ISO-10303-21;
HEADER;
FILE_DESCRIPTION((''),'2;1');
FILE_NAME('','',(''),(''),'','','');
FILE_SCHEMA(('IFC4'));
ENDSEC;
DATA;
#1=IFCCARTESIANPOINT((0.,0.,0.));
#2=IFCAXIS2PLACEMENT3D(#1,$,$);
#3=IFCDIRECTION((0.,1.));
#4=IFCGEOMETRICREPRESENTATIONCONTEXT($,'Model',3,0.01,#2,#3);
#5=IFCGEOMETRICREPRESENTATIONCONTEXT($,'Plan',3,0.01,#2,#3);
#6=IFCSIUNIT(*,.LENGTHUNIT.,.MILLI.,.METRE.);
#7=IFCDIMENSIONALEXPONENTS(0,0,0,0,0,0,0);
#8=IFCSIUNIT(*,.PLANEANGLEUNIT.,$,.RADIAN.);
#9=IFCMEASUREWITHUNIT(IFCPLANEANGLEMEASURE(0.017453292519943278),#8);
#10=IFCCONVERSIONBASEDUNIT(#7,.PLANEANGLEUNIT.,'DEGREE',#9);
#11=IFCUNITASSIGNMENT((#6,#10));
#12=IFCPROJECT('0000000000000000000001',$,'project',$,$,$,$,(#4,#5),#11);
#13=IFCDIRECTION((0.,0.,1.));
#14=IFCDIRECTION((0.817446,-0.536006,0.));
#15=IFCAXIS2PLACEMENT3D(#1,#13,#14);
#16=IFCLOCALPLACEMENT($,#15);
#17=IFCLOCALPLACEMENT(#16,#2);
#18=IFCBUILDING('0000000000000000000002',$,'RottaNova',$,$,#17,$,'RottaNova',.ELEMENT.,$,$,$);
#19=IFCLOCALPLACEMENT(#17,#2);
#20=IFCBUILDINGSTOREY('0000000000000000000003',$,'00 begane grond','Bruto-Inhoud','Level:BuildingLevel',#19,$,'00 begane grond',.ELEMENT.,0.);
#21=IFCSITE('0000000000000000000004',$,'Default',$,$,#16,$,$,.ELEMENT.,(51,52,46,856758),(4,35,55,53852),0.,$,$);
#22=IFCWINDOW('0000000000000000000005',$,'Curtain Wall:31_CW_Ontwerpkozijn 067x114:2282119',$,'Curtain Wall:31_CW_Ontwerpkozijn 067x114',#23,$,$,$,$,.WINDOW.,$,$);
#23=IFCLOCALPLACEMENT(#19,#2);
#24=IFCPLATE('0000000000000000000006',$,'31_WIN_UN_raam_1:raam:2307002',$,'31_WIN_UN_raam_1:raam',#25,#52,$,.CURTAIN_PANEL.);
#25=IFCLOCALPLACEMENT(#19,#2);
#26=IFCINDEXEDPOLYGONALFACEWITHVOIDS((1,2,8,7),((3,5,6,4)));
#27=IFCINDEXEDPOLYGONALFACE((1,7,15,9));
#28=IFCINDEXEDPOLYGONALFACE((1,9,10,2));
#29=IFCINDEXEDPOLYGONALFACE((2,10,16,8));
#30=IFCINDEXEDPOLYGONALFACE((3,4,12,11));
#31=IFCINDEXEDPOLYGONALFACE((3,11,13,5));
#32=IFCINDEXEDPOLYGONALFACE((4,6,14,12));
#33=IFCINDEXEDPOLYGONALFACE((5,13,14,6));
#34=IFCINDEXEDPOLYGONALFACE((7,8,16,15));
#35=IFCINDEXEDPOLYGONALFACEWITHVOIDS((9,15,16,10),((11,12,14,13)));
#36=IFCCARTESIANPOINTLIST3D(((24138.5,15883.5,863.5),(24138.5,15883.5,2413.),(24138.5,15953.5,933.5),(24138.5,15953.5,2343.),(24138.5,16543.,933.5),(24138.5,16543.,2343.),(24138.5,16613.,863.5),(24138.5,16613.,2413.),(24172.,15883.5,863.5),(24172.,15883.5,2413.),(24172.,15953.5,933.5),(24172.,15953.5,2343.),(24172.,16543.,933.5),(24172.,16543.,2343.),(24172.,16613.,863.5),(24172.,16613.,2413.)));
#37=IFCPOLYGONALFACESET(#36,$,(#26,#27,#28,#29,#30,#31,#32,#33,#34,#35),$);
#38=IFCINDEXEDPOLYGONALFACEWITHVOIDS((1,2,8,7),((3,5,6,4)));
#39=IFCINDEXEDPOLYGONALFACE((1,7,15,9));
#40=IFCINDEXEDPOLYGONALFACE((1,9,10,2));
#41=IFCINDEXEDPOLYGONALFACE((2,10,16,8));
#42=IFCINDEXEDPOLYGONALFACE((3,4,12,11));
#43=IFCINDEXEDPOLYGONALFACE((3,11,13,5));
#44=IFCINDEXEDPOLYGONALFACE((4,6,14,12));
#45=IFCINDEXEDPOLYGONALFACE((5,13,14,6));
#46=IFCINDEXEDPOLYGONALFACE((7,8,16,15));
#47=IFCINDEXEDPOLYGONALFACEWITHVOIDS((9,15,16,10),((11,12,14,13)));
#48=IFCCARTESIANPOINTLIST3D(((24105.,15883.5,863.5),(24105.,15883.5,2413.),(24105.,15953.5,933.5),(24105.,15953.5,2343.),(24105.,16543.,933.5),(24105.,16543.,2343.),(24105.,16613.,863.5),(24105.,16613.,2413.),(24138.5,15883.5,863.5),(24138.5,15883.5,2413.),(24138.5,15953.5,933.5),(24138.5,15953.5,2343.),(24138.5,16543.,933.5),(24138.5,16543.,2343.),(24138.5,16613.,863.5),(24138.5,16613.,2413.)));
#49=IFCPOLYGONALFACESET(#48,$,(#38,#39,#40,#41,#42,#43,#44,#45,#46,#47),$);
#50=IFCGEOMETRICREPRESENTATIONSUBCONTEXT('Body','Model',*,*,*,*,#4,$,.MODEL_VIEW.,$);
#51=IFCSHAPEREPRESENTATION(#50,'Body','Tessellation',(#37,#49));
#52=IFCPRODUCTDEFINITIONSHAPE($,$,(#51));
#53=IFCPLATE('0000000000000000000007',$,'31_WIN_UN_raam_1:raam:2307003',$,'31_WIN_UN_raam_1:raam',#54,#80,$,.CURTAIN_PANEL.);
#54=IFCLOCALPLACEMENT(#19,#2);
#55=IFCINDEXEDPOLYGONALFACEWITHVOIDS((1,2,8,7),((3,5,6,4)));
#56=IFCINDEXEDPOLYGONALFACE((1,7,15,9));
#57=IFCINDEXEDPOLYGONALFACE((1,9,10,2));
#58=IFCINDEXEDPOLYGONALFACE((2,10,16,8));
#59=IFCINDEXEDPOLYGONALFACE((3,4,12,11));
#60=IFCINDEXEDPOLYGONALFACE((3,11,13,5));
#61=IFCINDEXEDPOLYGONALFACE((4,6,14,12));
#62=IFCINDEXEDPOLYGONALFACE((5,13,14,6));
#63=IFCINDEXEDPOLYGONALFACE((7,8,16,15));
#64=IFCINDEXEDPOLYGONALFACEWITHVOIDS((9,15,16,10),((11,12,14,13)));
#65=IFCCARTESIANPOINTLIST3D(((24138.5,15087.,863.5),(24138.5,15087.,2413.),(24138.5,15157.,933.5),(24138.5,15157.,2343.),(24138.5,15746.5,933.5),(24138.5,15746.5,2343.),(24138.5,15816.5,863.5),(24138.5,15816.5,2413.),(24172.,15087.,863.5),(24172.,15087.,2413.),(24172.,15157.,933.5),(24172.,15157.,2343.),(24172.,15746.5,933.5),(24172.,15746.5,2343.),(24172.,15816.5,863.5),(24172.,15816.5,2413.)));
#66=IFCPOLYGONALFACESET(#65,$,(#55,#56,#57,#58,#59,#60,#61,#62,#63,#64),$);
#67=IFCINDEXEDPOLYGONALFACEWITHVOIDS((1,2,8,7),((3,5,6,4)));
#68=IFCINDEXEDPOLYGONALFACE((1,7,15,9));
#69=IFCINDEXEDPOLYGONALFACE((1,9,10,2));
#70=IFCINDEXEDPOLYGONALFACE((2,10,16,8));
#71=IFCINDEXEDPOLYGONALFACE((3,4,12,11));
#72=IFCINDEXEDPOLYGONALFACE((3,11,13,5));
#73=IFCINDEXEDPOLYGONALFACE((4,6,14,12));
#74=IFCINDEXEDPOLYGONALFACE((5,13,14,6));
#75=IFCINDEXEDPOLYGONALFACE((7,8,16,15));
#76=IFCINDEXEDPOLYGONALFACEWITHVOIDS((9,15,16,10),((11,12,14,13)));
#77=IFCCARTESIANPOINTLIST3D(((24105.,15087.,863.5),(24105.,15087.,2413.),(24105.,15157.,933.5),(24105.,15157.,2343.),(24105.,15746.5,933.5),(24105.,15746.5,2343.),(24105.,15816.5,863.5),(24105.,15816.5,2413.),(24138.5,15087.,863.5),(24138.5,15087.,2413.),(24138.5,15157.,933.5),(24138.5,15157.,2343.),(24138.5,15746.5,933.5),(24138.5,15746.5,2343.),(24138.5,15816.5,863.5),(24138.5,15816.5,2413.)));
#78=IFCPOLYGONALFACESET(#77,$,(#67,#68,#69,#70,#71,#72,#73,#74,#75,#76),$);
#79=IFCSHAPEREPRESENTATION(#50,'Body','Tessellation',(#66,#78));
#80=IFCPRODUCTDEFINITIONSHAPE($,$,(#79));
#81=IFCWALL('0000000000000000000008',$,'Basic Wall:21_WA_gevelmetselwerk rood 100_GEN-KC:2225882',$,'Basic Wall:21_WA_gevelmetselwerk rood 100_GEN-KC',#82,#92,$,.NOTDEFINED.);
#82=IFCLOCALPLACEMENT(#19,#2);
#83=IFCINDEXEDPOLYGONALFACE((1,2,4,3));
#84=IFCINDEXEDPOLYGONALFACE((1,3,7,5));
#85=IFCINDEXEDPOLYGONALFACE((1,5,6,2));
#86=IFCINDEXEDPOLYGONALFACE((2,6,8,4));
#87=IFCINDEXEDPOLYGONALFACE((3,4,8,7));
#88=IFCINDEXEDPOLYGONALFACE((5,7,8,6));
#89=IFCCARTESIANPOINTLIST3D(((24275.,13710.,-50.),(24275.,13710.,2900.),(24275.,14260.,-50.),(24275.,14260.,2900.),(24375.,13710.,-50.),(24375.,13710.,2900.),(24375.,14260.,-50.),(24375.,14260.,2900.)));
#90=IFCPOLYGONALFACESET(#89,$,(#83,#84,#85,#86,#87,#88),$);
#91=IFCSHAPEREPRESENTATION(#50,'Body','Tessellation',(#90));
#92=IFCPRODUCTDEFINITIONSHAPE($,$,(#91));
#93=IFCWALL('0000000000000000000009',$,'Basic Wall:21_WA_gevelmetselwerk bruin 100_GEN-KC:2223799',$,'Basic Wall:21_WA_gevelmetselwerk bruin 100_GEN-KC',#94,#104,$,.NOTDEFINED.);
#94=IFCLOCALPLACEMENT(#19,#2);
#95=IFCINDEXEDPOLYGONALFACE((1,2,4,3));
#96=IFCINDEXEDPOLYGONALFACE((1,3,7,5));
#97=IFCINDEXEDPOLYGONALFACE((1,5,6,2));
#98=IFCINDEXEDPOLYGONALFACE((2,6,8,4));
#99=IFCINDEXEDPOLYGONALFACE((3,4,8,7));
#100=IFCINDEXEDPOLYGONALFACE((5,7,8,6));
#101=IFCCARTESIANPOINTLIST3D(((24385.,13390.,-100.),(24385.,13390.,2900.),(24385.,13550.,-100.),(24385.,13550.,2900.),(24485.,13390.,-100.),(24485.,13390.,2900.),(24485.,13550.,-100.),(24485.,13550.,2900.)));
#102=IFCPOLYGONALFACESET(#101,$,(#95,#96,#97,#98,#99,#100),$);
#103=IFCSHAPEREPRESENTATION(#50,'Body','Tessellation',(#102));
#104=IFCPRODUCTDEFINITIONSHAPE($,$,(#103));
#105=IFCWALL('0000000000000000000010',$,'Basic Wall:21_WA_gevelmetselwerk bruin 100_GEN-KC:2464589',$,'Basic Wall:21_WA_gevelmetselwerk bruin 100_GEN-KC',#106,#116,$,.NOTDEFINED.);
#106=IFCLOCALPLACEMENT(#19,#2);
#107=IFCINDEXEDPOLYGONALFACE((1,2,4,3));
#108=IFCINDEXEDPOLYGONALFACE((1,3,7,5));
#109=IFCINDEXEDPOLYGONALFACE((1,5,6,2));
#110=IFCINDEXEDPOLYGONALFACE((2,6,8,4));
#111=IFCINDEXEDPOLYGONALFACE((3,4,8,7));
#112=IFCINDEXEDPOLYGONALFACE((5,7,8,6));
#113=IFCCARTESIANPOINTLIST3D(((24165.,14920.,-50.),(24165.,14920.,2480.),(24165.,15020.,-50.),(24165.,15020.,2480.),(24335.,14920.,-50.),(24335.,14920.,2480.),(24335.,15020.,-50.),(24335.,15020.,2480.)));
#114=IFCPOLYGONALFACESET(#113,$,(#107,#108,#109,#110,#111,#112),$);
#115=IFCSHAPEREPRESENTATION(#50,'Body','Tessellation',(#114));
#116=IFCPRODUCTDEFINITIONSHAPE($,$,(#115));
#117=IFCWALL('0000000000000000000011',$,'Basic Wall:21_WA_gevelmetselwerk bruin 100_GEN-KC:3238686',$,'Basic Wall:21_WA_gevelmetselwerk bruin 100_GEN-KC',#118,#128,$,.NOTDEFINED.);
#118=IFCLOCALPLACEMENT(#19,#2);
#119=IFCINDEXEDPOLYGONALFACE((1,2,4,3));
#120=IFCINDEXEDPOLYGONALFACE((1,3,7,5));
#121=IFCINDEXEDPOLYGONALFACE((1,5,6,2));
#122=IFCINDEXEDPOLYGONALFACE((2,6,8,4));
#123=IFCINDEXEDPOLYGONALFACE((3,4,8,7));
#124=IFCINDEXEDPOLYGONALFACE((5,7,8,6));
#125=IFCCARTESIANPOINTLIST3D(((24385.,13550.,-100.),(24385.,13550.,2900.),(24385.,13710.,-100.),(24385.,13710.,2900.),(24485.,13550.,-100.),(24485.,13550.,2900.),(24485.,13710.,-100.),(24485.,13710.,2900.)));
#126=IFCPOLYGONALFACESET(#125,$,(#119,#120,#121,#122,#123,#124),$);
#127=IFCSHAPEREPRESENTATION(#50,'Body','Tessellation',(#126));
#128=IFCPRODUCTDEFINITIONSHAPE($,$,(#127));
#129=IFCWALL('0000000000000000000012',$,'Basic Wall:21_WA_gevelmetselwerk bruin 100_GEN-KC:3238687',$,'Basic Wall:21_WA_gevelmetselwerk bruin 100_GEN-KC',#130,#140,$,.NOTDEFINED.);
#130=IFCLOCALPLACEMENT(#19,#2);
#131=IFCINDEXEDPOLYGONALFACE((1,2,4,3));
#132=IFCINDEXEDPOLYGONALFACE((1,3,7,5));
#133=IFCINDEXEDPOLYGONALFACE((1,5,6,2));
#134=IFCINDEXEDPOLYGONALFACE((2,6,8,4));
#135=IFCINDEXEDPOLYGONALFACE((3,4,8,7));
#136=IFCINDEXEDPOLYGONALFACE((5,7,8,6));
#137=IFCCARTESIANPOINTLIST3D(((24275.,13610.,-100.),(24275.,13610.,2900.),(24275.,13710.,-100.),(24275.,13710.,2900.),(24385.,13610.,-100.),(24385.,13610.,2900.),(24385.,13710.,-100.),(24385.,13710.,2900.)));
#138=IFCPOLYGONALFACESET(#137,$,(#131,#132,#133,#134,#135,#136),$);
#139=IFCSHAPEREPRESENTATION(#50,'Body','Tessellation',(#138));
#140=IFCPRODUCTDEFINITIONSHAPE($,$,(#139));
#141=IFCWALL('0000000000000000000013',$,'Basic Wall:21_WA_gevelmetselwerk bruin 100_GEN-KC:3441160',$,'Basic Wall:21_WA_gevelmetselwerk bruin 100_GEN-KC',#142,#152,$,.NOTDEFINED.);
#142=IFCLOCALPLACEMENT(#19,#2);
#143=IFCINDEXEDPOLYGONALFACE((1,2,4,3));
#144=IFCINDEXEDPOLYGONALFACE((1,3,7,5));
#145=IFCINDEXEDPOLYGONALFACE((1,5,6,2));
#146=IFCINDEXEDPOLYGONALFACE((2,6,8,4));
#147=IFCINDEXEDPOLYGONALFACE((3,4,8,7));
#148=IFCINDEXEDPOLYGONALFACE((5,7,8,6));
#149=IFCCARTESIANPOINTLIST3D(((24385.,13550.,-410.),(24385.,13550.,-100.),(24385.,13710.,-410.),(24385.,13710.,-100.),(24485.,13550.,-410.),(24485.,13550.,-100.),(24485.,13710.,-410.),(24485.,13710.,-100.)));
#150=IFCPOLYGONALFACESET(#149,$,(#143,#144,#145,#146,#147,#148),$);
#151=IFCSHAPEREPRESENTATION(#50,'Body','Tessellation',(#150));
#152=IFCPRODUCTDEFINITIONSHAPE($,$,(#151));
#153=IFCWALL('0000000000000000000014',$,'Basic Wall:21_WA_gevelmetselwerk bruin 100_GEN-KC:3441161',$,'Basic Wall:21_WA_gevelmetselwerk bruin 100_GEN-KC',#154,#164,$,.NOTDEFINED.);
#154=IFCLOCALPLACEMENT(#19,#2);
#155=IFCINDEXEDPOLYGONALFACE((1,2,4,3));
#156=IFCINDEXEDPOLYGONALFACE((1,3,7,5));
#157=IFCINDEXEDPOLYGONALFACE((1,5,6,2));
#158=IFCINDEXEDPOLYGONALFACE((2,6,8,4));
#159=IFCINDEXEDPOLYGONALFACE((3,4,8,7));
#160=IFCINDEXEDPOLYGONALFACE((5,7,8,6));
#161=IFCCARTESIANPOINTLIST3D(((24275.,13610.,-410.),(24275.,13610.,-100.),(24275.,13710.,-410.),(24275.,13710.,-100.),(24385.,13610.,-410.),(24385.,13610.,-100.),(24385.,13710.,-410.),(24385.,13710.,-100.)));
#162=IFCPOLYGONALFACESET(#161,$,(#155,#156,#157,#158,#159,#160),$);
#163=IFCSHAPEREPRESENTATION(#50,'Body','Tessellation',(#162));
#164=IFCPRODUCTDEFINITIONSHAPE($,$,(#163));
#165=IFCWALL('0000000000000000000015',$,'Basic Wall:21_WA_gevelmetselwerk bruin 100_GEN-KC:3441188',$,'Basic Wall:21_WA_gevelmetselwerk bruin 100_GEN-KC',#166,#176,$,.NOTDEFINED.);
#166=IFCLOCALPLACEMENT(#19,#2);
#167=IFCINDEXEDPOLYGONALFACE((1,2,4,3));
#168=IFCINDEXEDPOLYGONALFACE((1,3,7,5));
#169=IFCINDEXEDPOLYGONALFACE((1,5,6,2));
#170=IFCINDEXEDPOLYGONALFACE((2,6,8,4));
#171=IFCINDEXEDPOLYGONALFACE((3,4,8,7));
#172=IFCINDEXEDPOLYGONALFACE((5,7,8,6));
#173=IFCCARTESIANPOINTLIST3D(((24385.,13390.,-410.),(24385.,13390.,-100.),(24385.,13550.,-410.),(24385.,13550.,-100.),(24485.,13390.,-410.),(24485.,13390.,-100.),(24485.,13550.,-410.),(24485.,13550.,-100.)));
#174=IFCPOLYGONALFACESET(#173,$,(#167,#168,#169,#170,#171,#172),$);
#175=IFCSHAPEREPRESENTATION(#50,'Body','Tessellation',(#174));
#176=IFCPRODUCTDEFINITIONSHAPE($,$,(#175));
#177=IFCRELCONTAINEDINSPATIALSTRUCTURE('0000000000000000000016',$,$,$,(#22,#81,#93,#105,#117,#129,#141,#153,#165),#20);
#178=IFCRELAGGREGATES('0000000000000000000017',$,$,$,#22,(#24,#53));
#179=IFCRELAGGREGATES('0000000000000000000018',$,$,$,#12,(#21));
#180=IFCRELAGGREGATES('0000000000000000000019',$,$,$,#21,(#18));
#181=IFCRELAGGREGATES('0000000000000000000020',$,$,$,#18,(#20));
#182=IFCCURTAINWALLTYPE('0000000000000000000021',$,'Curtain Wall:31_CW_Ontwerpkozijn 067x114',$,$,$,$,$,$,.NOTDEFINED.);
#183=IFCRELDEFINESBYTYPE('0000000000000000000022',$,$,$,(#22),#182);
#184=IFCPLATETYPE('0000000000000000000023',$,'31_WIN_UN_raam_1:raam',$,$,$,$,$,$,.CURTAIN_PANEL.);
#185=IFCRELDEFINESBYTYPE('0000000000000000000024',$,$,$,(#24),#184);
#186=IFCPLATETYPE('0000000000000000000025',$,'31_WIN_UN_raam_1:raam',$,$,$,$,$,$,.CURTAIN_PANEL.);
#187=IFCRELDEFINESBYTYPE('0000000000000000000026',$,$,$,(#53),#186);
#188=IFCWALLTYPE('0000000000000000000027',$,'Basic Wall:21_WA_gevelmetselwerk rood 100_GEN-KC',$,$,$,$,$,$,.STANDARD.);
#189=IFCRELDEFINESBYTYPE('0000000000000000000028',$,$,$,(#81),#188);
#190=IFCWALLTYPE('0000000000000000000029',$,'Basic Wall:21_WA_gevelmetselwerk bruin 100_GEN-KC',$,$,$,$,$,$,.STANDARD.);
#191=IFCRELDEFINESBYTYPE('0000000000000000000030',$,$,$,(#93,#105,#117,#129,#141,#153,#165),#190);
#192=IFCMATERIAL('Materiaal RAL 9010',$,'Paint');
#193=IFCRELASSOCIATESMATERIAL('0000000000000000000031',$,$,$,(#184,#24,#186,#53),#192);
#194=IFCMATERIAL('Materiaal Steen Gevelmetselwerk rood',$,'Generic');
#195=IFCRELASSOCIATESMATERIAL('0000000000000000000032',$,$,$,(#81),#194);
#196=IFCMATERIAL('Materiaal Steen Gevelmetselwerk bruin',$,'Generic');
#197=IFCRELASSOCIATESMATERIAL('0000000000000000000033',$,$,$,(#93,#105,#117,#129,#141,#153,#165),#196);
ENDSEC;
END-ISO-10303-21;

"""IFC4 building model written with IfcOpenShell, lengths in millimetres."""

from ifc_helpers import new_model, entity, si_unit, converted_unit, direction, frame, origin, place, context, subcontext, project, spatial, indexed_curve, outline, extrude, source, transform, mapped, material, type_object, type_shapes, element, aggregate, save


model = new_model("IFC4")

# Units and contexts
model_context = context("Model", 3, precision=0.01, world=origin(), true_north=direction((0.0, 1.0)))
plan_context = context("Plan", 3, precision=0.01, world=origin(), true_north=direction((0.0, 1.0)))
body_context = subcontext(model_context, "Body", "Model", "MODEL_VIEW")
ifc_project = project(units=[si_unit("LENGTHUNIT", "METRE", prefix="MILLI"), converted_unit("PLANEANGLEUNIT", "DEGREE", entity("IfcPlaneAngleMeasure", 0.017453292519943278), si_unit("PLANEANGLEUNIT", "RADIAN"), dimensions=[0, 0, 0, 0, 0, 0, 0])], contexts=[model_context, plan_context])

# Site, building, storey
site_placement = place(None, frame((0.0, 0.0, 0.0), z_axis=(0.0, 0.0, 1.0), x_axis=(0.817446, -0.536006, 0.0)))
site = spatial("IfcSite", under=ifc_project, at=site_placement, Name="Default", CompositionType="ELEMENT", RefLatitude=(51, 52, 46, 856758), RefLongitude=(4, 35, 55, 53852), RefElevation=0.0)
building_placement = place(site_placement, origin())
building = spatial("IfcBuilding", under=site, at=building_placement, Name="RottaNova", LongName="RottaNova", CompositionType="ELEMENT")
storey_placement = place(building_placement, origin())
storey = spatial("IfcBuildingStorey", under=building, at=storey_placement, Name="00 begane grond", Description="Bruto-Inhoud", ObjectType="Level:BuildingLevel", LongName="00 begane grond", CompositionType="ELEMENT", Elevation=0.0)

# Window, plates
curtain_wall_type = type_object("IfcCurtainWallType", Name="Curtain Wall:31_CW_Ontwerpkozijn 067x114", PredefinedType="NOTDEFINED")
window_placement = place(storey_placement, origin())
window = element("IfcWindow", 1, at=window_placement, inside=storey, type_object=curtain_wall_type, Name="Curtain Wall:31_CW_Ontwerpkozijn 067x114:2282119", ObjectType="Curtain Wall:31_CW_Ontwerpkozijn 067x114", PredefinedType="WINDOW")
ifc_material_1 = material(Name="Materiaal RAL 9010", Category="Paint")
plate_type_1 = type_object("IfcPlateType", Name="31_WIN_UN_raam_1:raam", PredefinedType="CURTAIN_PANEL", material=ifc_material_1)
shared_shape_1 = source(origin(), body_context, "Body", "SweptSolid", [
    extrude(outline(indexed_curve([(-364.7, -774.7), (364.7, -774.7), (364.7, 774.7), (-364.7, 774.7), (-364.7, -774.7)], self_intersect=False), holes=[indexed_curve([(-294.7, 704.7), (294.7, 704.7), (294.7, -704.8), (-294.7, -704.8), (-294.7, 704.7)], self_intersect=False)]), frame((0.0, 58.5, 774.8), z_axis=(0.0, 1.0, 0.0), x_axis=(1.0, 0.0, 0.0)), (0.0, 0.0, 1.0), 33.5),
    extrude(outline(indexed_curve([(-364.7, -774.7), (364.7, -774.7), (364.7, 774.7), (-364.7, 774.7), (-364.7, -774.7)], self_intersect=False), holes=[indexed_curve([(-294.7, 704.7), (294.7, 704.7), (294.7, -704.8), (-294.7, -704.8), (-294.7, 704.7)], self_intersect=False)]), frame((0.0, 25.0, 774.8), z_axis=(0.0, 1.0, 0.0), x_axis=(1.0, 0.0, 0.0)), (0.0, 0.0, 1.0), 33.5),
])
type_shapes(plate_type_1, [shared_shape_1])
plate_1_placement = place(window_placement, frame((24080.0, 16248.3, 863.5), z_axis=(0.0, 0.0, 1.0), x_axis=(0.0, -1.0, 0.0)))
plate_1 = element("IfcPlate", 2, at=plate_1_placement, type_object=plate_type_1, material=ifc_material_1, Name="31_WIN_UN_raam_1:raam:2307002", ObjectType="31_WIN_UN_raam_1:raam", PredefinedType="CURTAIN_PANEL", context=body_context, shape_type="MappedRepresentation", body=[
    mapped(shared_shape_1, transform((0.0, 0.0, 0.0), scale=1.0)),
])
plate_type_2 = type_object("IfcPlateType", Name="31_WIN_UN_raam_1:raam", PredefinedType="CURTAIN_PANEL", material=ifc_material_1)
shared_shape_2 = source(origin(), body_context, "Body", "SweptSolid", [
    extrude(outline(indexed_curve([(-364.7, -774.7), (364.7, -774.7), (364.7, 774.7), (-364.7, 774.7), (-364.7, -774.7)], self_intersect=False), holes=[indexed_curve([(-294.7, 704.7), (294.7, 704.7), (294.7, -704.8), (-294.7, -704.8), (-294.7, 704.7)], self_intersect=False)]), frame((0.0, 58.5, 774.8), z_axis=(0.0, 1.0, 0.0), x_axis=(1.0, 0.0, 0.0)), (0.0, 0.0, 1.0), 33.5),
    extrude(outline(indexed_curve([(-364.7, -774.7), (364.7, -774.7), (364.7, 774.7), (-364.7, 774.7), (-364.7, -774.7)], self_intersect=False), holes=[indexed_curve([(-294.7, 704.7), (294.7, 704.7), (294.7, -704.8), (-294.7, -704.8), (-294.7, 704.7)], self_intersect=False)]), frame((0.0, 25.0, 774.8), z_axis=(0.0, 1.0, 0.0), x_axis=(1.0, 0.0, 0.0)), (0.0, 0.0, 1.0), 33.5),
])
type_shapes(plate_type_2, [shared_shape_2])
plate_2_placement = place(window_placement, frame((24080.0, 15451.8, 863.5), z_axis=(0.0, 0.0, 1.0), x_axis=(0.0, -1.0, 0.0)))
plate_2 = element("IfcPlate", 3, at=plate_2_placement, type_object=plate_type_2, material=ifc_material_1, Name="31_WIN_UN_raam_1:raam:2307003", ObjectType="31_WIN_UN_raam_1:raam", PredefinedType="CURTAIN_PANEL", context=body_context, shape_type="MappedRepresentation", body=[
    mapped(shared_shape_2, transform((0.0, 0.0, 0.0), scale=1.0)),
])
aggregate(window, [plate_1, plate_2])

# Walls
ifc_material_2 = material(Name="Materiaal Steen Gevelmetselwerk rood", Category="Generic")
wall_type_1 = type_object("IfcWallType", Name="Basic Wall:21_WA_gevelmetselwerk rood 100_GEN-KC", PredefinedType="STANDARD")
wall_1_placement = place(storey_placement, frame((24325.0, 13710.0, -50.0), z_axis=(0.0, 0.0, 1.0), x_axis=(0.0, 1.0, 0.0)))
element("IfcWall", 4, at=wall_1_placement, inside=storey, type_object=wall_type_1, material=ifc_material_2, Name="Basic Wall:21_WA_gevelmetselwerk rood 100_GEN-KC:2225882", ObjectType="Basic Wall:21_WA_gevelmetselwerk rood 100_GEN-KC", PredefinedType="NOTDEFINED", context=body_context, shape_type="SweptSolid", body=[
    extrude(outline(indexed_curve([(550.0, 50.0), (0.0, 50.0), (0.0, -50.0), (550.0, -50.0), (550.0, 50.0)], self_intersect=False)), origin(), (0.0, 0.0, 1.0), 2950.0),
])
ifc_material_3 = material(Name="Materiaal Steen Gevelmetselwerk bruin", Category="Generic")
wall_type_2 = type_object("IfcWallType", Name="Basic Wall:21_WA_gevelmetselwerk bruin 100_GEN-KC", PredefinedType="STANDARD")
wall_2_placement = place(storey_placement, frame((24435.0, 13550.0, -100.0), z_axis=(0.0, 0.0, 1.0), x_axis=(0.0, -1.0, 0.0)))
element("IfcWall", 5, at=wall_2_placement, inside=storey, type_object=wall_type_2, material=ifc_material_3, Name="Basic Wall:21_WA_gevelmetselwerk bruin 100_GEN-KC:2223799", ObjectType="Basic Wall:21_WA_gevelmetselwerk bruin 100_GEN-KC", PredefinedType="NOTDEFINED", context=body_context, shape_type="SweptSolid", body=[
    extrude(outline(indexed_curve([(160.0, 50.0), (0.0, 50.0), (0.0, -50.0), (160.0, -50.0), (160.0, 50.0)], self_intersect=False)), origin(), (0.0, 0.0, 1.0), 3000.0),
])
wall_3_placement = place(storey_placement, frame((24335.0, 14970.0, -50.0), z_axis=(0.0, 0.0, 1.0), x_axis=(-1.0, 0.0, 0.0)))
element("IfcWall", 6, at=wall_3_placement, inside=storey, type_object=wall_type_2, material=ifc_material_3, Name="Basic Wall:21_WA_gevelmetselwerk bruin 100_GEN-KC:2464589", ObjectType="Basic Wall:21_WA_gevelmetselwerk bruin 100_GEN-KC", PredefinedType="NOTDEFINED", context=body_context, shape_type="SweptSolid", body=[
    extrude(outline(indexed_curve([(170.0, 50.0), (0.0, 50.0), (0.0, -50.0), (170.0, -50.0), (170.0, 50.0)], self_intersect=False)), origin(), (0.0, 0.0, 1.0), 2530.0),
])
wall_4_placement = place(storey_placement, frame((24435.0, 13550.0, -100.0), z_axis=(0.0, 0.0, 1.0), x_axis=(0.0, 1.0, 0.0)))
element("IfcWall", 7, at=wall_4_placement, inside=storey, type_object=wall_type_2, material=ifc_material_3, Name="Basic Wall:21_WA_gevelmetselwerk bruin 100_GEN-KC:3238686", ObjectType="Basic Wall:21_WA_gevelmetselwerk bruin 100_GEN-KC", PredefinedType="NOTDEFINED", context=body_context, shape_type="SweptSolid", body=[
    extrude(outline(indexed_curve([(160.0, 50.0), (0.0, 50.0), (0.0, -50.0), (160.0, -50.0), (160.0, 50.0)], self_intersect=False)), origin(), (0.0, 0.0, 1.0), 3000.0),
])
wall_5_placement = place(storey_placement, frame((24385.0, 13660.0, -100.0), z_axis=(0.0, 0.0, 1.0), x_axis=(-1.0, 0.0, 0.0)))
element("IfcWall", 8, at=wall_5_placement, inside=storey, type_object=wall_type_2, material=ifc_material_3, Name="Basic Wall:21_WA_gevelmetselwerk bruin 100_GEN-KC:3238687", ObjectType="Basic Wall:21_WA_gevelmetselwerk bruin 100_GEN-KC", PredefinedType="NOTDEFINED", context=body_context, shape_type="SweptSolid", body=[
    extrude(outline(indexed_curve([(110.0, 50.0), (0.0, 50.0), (0.0, -50.0), (110.0, -50.0), (110.0, 50.0)], self_intersect=False)), origin(), (0.0, 0.0, 1.0), 3000.0),
])
wall_6_placement = place(storey_placement, frame((24435.0, 13550.0, -410.0), z_axis=(0.0, 0.0, 1.0), x_axis=(0.0, 1.0, 0.0)))
element("IfcWall", 9, at=wall_6_placement, inside=storey, type_object=wall_type_2, material=ifc_material_3, Name="Basic Wall:21_WA_gevelmetselwerk bruin 100_GEN-KC:3441160", ObjectType="Basic Wall:21_WA_gevelmetselwerk bruin 100_GEN-KC", PredefinedType="NOTDEFINED", context=body_context, shape_type="SweptSolid", body=[
    extrude(outline(indexed_curve([(160.0, 50.0), (0.0, 50.0), (0.0, -50.0), (160.0, -50.0), (160.0, 50.0)], self_intersect=False)), origin(), (0.0, 0.0, 1.0), 310.0),
])
wall_7_placement = place(storey_placement, frame((24385.0, 13660.0, -410.0), z_axis=(0.0, 0.0, 1.0), x_axis=(-1.0, 0.0, 0.0)))
element("IfcWall", 10, at=wall_7_placement, inside=storey, type_object=wall_type_2, material=ifc_material_3, Name="Basic Wall:21_WA_gevelmetselwerk bruin 100_GEN-KC:3441161", ObjectType="Basic Wall:21_WA_gevelmetselwerk bruin 100_GEN-KC", PredefinedType="NOTDEFINED", context=body_context, shape_type="SweptSolid", body=[
    extrude(outline(indexed_curve([(110.0, 50.0), (0.0, 50.0), (0.0, -50.0), (110.0, -50.0), (110.0, 50.0)], self_intersect=False)), origin(), (0.0, 0.0, 1.0), 310.0),
])
wall_8_placement = place(storey_placement, frame((24435.0, 13550.0, -410.0), z_axis=(0.0, 0.0, 1.0), x_axis=(0.0, -1.0, 0.0)))
element("IfcWall", 11, at=wall_8_placement, inside=storey, type_object=wall_type_2, material=ifc_material_3, Name="Basic Wall:21_WA_gevelmetselwerk bruin 100_GEN-KC:3441188", ObjectType="Basic Wall:21_WA_gevelmetselwerk bruin 100_GEN-KC", PredefinedType="NOTDEFINED", context=body_context, shape_type="SweptSolid", body=[
    extrude(outline(indexed_curve([(160.0, 50.0), (0.0, 50.0), (0.0, -50.0), (160.0, -50.0), (160.0, 50.0)], self_intersect=False)), origin(), (0.0, 0.0, 1.0), 310.0),
])

save(model, "model.ifc")
